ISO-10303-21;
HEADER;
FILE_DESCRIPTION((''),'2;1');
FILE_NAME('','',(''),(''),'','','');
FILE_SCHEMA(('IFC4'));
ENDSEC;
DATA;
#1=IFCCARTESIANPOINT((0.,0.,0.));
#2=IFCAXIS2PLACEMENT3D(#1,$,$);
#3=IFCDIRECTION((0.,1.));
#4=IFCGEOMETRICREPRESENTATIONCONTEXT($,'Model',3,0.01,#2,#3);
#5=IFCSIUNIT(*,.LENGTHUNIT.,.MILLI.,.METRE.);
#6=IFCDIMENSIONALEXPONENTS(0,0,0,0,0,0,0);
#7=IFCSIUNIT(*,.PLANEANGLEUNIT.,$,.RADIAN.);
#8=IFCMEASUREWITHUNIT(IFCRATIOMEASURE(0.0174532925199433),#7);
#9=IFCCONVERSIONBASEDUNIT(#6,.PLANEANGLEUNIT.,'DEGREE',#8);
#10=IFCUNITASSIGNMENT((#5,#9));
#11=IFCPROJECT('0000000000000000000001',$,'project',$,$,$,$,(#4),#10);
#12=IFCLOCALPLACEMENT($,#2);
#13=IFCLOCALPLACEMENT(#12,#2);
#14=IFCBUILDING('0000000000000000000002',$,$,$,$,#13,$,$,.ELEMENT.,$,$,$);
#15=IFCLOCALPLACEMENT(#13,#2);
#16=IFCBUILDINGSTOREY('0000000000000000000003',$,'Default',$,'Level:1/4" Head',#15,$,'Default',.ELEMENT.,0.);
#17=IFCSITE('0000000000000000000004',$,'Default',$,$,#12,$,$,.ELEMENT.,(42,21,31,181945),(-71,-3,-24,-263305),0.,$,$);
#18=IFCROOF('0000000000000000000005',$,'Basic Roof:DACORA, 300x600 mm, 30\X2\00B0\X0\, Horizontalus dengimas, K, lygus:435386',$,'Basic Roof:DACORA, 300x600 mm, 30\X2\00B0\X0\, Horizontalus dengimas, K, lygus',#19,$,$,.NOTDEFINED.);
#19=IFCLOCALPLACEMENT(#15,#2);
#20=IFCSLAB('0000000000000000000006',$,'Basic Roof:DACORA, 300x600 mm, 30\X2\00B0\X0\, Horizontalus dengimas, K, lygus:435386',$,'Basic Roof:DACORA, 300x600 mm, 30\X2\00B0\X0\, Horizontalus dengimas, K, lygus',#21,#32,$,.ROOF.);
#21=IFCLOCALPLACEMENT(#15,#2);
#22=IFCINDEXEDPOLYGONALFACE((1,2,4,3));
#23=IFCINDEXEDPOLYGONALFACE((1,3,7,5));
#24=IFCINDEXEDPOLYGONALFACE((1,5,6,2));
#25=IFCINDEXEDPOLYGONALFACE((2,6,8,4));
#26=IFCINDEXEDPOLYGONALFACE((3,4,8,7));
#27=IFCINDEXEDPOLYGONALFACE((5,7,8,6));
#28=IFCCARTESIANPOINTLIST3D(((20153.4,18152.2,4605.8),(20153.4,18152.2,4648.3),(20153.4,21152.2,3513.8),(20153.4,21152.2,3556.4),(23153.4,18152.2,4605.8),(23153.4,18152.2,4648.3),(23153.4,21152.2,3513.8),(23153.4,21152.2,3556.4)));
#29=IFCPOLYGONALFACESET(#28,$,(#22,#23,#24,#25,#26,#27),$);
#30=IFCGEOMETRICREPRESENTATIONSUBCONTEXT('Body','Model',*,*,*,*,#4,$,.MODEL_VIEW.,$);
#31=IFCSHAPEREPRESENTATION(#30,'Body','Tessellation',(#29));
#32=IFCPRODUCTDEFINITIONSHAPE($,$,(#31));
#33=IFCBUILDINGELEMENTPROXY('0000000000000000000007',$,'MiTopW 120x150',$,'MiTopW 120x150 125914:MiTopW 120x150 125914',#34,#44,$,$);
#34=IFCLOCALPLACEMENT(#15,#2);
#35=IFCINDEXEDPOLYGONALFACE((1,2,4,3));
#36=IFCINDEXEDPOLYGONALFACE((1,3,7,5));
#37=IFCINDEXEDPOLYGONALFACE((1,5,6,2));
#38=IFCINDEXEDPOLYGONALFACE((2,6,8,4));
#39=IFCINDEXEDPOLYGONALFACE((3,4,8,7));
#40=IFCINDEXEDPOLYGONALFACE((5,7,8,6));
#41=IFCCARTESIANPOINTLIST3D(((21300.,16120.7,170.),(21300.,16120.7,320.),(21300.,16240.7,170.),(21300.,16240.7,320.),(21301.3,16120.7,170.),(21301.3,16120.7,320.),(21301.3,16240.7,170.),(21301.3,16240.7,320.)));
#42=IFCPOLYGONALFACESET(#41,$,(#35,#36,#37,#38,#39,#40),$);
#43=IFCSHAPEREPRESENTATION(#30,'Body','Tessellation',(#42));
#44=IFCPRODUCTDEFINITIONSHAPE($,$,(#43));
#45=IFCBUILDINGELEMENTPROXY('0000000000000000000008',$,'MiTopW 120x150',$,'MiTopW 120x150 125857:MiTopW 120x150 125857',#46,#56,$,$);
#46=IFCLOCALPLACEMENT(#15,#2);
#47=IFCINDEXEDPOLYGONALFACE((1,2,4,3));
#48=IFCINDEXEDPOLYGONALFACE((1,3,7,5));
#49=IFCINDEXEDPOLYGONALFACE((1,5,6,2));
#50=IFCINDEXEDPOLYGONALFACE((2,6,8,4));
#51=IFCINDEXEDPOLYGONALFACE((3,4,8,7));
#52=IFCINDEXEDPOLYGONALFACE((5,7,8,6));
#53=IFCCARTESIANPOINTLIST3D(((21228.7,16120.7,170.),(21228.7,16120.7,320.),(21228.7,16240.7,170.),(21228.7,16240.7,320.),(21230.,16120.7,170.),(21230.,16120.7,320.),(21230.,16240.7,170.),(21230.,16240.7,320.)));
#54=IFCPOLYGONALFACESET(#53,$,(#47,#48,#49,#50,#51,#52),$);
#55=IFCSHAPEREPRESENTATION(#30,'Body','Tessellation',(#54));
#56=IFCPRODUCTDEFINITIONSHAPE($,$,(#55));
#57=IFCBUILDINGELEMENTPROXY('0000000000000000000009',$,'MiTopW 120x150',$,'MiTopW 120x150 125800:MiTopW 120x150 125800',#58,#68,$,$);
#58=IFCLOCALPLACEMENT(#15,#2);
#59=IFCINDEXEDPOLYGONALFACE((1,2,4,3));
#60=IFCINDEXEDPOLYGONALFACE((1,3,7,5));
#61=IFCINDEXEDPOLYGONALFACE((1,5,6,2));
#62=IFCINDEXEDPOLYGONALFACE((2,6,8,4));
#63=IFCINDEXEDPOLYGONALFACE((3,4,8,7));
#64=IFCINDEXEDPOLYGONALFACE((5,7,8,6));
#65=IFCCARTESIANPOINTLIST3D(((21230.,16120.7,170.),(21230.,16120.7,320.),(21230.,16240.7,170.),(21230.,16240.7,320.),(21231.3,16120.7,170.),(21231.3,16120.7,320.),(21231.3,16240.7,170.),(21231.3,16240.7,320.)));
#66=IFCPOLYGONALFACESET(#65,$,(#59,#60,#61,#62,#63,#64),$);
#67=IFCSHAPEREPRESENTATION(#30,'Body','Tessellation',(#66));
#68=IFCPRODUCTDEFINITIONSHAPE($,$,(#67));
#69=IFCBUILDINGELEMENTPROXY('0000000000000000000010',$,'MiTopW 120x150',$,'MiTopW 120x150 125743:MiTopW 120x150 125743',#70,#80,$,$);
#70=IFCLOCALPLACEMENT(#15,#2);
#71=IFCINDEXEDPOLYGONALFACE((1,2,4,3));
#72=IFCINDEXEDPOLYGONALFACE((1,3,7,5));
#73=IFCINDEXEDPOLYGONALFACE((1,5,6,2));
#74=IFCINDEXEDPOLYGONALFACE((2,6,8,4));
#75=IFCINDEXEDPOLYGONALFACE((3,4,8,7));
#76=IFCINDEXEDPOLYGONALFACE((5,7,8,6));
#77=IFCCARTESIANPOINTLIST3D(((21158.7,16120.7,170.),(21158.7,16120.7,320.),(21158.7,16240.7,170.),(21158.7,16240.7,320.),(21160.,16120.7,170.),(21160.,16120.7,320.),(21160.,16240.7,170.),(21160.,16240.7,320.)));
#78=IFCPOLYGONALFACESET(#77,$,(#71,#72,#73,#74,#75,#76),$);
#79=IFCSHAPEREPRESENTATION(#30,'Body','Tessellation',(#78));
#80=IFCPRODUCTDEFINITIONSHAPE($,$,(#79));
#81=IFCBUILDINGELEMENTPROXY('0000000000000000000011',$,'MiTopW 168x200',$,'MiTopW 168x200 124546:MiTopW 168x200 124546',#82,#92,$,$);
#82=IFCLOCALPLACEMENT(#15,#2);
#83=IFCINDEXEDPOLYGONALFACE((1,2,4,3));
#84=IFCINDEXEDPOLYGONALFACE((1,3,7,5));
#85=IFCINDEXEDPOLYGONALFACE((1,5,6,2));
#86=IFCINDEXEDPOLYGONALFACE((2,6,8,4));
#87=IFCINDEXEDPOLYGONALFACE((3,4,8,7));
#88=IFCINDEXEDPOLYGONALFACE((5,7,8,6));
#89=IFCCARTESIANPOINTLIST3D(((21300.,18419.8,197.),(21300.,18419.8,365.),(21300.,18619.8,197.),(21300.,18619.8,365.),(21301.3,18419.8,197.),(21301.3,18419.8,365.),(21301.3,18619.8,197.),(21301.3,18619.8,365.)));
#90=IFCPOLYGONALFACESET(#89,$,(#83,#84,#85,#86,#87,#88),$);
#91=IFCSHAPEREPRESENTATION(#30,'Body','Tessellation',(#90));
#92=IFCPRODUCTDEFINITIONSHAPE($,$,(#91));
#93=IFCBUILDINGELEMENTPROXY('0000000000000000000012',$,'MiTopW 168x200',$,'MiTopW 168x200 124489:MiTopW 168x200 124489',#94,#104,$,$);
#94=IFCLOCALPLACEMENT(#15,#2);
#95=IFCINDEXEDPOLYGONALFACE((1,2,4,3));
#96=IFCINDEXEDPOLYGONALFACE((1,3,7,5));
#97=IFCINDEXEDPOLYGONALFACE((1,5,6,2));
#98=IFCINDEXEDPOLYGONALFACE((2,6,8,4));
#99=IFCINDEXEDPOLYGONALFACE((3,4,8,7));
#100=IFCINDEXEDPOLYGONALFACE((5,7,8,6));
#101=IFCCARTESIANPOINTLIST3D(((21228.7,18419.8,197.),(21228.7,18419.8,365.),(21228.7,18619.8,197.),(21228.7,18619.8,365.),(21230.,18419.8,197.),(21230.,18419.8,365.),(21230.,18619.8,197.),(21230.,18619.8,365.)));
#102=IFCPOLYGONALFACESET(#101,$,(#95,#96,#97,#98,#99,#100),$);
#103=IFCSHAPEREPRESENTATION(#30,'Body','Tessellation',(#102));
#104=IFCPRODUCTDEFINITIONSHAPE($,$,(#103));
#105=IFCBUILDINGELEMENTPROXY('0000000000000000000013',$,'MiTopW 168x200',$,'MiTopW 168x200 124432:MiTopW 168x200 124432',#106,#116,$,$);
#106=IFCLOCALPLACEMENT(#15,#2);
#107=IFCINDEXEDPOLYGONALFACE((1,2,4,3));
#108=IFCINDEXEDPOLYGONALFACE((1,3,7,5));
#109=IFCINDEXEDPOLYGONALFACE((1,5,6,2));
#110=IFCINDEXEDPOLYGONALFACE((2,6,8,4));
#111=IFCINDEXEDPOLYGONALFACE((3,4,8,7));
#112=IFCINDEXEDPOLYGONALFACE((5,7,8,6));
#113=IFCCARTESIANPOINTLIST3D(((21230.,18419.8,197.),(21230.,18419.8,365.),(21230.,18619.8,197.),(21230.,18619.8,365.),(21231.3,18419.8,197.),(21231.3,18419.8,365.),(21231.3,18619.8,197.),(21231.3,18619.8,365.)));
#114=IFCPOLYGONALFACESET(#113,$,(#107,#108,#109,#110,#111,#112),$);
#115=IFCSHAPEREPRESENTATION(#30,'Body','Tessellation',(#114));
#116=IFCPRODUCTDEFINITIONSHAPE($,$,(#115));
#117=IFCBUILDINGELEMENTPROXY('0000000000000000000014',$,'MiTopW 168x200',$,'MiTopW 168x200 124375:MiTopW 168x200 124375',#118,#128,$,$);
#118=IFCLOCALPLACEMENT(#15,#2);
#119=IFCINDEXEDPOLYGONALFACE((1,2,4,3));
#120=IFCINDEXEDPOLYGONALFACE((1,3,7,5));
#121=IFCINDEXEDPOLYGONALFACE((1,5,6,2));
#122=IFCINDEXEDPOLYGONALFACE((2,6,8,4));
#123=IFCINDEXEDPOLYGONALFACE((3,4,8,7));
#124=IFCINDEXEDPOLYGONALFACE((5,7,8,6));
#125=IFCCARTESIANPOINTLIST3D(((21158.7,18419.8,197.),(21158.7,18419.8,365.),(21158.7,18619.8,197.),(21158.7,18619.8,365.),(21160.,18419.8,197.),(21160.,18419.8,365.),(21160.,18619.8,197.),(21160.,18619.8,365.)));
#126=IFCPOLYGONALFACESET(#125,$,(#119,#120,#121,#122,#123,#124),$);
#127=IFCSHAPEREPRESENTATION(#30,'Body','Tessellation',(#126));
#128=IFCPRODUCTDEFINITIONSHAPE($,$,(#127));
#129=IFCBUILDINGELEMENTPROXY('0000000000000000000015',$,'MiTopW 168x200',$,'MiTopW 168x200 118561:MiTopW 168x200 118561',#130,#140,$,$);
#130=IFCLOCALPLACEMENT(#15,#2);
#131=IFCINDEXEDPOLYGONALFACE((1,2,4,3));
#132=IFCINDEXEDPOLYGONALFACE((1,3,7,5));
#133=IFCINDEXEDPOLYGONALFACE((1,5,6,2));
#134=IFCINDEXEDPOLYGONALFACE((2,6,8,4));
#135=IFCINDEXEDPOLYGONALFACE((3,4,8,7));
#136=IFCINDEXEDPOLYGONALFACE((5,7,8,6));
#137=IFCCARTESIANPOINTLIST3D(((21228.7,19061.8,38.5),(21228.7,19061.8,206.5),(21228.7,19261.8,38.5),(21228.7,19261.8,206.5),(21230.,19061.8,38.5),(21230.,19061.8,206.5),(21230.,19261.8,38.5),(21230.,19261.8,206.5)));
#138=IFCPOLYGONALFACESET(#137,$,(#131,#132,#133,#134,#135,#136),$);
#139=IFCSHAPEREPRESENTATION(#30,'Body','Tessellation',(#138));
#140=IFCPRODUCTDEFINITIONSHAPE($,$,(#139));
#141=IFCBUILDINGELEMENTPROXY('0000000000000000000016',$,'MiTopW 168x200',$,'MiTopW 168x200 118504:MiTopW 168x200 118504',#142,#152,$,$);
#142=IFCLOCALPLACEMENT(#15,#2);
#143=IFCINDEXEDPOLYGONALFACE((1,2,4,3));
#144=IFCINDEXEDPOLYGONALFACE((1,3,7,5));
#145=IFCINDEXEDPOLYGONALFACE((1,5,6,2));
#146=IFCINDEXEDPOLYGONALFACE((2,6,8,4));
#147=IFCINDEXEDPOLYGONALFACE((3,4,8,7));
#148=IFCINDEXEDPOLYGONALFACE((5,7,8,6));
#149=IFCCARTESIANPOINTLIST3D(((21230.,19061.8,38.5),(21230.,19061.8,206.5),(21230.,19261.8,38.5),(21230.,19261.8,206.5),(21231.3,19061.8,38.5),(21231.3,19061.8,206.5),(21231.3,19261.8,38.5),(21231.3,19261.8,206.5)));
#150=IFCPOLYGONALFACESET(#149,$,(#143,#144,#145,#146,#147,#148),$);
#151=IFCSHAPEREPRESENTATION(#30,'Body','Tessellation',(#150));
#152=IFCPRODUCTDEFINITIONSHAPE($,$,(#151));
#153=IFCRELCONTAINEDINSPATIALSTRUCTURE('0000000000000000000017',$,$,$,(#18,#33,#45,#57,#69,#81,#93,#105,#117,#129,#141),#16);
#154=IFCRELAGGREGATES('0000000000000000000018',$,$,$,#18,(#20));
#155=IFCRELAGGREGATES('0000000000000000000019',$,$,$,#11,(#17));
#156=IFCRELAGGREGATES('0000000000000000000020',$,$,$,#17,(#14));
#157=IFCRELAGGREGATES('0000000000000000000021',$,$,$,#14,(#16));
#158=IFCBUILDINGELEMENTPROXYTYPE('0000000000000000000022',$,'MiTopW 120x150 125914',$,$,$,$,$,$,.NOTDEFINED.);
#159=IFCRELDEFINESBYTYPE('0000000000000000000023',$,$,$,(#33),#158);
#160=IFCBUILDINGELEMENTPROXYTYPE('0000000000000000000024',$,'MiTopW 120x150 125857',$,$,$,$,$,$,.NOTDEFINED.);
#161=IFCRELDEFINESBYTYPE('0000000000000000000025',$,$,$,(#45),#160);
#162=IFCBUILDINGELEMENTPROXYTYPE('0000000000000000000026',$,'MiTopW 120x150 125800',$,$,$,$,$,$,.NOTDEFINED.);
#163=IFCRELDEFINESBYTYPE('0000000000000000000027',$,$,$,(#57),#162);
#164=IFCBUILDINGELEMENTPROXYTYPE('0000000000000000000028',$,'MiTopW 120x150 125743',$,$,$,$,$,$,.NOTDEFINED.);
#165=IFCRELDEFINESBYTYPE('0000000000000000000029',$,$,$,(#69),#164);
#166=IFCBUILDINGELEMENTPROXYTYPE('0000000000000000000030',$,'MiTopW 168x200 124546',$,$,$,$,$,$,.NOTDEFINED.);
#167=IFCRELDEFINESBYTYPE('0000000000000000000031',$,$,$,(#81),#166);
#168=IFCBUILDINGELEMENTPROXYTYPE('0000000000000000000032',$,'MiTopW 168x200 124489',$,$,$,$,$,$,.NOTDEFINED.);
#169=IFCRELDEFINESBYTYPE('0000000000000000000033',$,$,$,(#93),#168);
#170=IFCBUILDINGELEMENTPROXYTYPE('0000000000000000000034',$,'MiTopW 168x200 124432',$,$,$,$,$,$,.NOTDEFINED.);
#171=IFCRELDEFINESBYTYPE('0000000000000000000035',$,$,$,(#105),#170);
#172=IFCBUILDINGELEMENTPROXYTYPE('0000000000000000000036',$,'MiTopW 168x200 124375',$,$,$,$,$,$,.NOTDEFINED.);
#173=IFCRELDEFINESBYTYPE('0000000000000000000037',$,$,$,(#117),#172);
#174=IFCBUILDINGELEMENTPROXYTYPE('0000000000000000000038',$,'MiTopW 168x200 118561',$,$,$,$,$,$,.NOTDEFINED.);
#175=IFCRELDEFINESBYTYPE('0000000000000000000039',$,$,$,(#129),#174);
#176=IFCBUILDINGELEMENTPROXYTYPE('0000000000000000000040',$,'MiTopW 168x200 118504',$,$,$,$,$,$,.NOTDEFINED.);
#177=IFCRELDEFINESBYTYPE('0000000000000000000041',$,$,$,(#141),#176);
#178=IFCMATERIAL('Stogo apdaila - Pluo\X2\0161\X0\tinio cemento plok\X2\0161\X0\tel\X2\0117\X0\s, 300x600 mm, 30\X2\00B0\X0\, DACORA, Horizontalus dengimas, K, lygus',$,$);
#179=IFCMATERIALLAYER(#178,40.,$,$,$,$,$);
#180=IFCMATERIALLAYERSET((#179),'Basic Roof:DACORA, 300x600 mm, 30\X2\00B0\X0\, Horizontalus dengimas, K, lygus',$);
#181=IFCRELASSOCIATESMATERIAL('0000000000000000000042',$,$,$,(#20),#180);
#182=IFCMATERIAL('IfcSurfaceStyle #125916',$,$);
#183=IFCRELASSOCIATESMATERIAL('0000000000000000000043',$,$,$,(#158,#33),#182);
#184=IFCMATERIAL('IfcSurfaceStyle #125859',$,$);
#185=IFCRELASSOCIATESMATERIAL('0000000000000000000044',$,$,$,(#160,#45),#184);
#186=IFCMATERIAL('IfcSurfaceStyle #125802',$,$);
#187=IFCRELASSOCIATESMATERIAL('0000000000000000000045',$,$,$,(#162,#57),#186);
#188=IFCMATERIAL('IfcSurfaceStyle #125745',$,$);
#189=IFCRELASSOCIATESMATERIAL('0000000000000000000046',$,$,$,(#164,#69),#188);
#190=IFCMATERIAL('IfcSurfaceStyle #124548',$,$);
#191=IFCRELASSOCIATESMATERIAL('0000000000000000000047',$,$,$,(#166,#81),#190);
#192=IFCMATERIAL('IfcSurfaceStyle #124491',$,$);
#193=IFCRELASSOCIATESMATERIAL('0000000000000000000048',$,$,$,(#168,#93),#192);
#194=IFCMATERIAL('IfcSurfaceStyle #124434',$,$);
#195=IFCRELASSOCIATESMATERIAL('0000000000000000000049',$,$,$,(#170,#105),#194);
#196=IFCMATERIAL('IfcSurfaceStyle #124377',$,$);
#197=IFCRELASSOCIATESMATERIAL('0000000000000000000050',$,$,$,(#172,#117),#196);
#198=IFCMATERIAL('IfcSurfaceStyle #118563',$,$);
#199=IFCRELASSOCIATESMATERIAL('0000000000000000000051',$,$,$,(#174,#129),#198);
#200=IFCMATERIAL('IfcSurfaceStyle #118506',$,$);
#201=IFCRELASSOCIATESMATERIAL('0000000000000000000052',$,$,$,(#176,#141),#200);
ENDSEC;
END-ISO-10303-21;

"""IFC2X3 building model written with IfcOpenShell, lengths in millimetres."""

from ifc_helpers import new_model, entity, si_unit, converted_unit, direction, frame, frame_2d, origin, origin_2d_with_axis, place, context, subcontext, project, spatial, rectangle, extrude, source, transform, mapped, material, layer, layer_set, type_object, type_shapes, element, aggregate, save


model = new_model("IFC2X3")

# Units and contexts
model_context = context("Model", 3, precision=0.01, world=origin(), true_north=direction((0.0, 1.0)))
body_context = subcontext(model_context, "Body", "Model", "MODEL_VIEW")
ifc_project = project(units=[si_unit("LENGTHUNIT", "METRE", prefix="MILLI"), converted_unit("PLANEANGLEUNIT", "DEGREE", entity("IfcRatioMeasure", 0.0174532925199433), si_unit("PLANEANGLEUNIT", "RADIAN"), dimensions=[0, 0, 0, 0, 0, 0, 0])], contexts=[model_context])

# Site, building, storey
site_placement = place(None, origin())
site = spatial("IfcSite", under=ifc_project, at=site_placement, Name="Default", CompositionType="ELEMENT", RefLatitude=(42, 21, 31, 181945), RefLongitude=(-71, -3, -24, -263305), RefElevation=0.0)
building_placement = place(site_placement, origin())
building = spatial("IfcBuilding", under=site, at=building_placement, CompositionType="ELEMENT")
storey_placement = place(building_placement, origin())
storey = spatial("IfcBuildingStorey", under=building, at=storey_placement, Name="Default", ObjectType="Level:1/4\" Head", LongName="Default", CompositionType="ELEMENT", Elevation=0.0)

# Roof, slab
roof_placement = place(storey_placement, frame((20153.4, 18152.2, 3513.8)))
roof = element("IfcRoof", 1, at=roof_placement, inside=storey, Name="Basic Roof:DACORA, 300x600 mm, 30°, Horizontalus dengimas, K, lygus:435386", ObjectType="Basic Roof:DACORA, 300x600 mm, 30°, Horizontalus dengimas, K, lygus", ShapeType="NOTDEFINED")
ifc_material_1 = material(Name="Stogo apdaila - Pluoštinio cemento plokštelės, 300x600 mm, 30°, DACORA, Horizontalus dengimas, K, lygus")
ifc_layer = layer(ifc_material_1, 40.0)
ifc_layer_set = layer_set([ifc_layer], Name="Basic Roof:DACORA, 300x600 mm, 30°, Horizontalus dengimas, K, lygus")
slab_placement = place(roof_placement, origin())
slab = element("IfcSlab", 2, at=slab_placement, material=ifc_layer_set, Name="Basic Roof:DACORA, 300x600 mm, 30°, Horizontalus dengimas, K, lygus:435386", ObjectType="Basic Roof:DACORA, 300x600 mm, 30°, Horizontalus dengimas, K, lygus", PredefinedType="ROOF", context=body_context, shape_type="SweptSolid", body=[
    extrude(rectangle(XDim=3192.5, YDim=3000.0, at=frame_2d((0.0, 0.0), x_axis=(0.0, 1.0))), frame((1500.0, 1500.0, 546.0), z_axis=(0.0, 0.34202, 0.939693), x_axis=(1.0, 0.0, 0.0)), (0.0, -0.34202, 0.939693), 42.6),
])
aggregate(roof, [slab])

# Building element proxies
ifc_material_2 = material(Name="IfcSurfaceStyle #125916")
building_element_proxy_type_1 = type_object("IfcBuildingElementProxyType", Name="MiTopW 120x150 125914", PredefinedType="NOTDEFINED", material=ifc_material_2)
shared_shape_1 = source(origin(), body_context, "Body", "SweptSolid", [
    extrude(rectangle(XDim=150.0, YDim=120.0, at=origin_2d_with_axis()), frame((75.0, 60.0, 0.0), z_axis=(0.0, 0.0, 1.0), x_axis=(-1.0, 0.0, 0.0)), (0.0, 0.0, 1.0), 1.3),
])
type_shapes(building_element_proxy_type_1, [shared_shape_1])
proxy_1_placement = place(building_placement, frame((21301.3, 16120.7, 170.0), z_axis=(-1.0, 0.0, 0.0), x_axis=(0.0, 0.0, 1.0)))
element("IfcBuildingElementProxy", 3, at=proxy_1_placement, inside=storey, type_object=building_element_proxy_type_1, material=ifc_material_2, Name="MiTopW 120x150", ObjectType="MiTopW 120x150 125914:MiTopW 120x150 125914", context=body_context, shape_type="MappedRepresentation", body=[
    mapped(shared_shape_1, transform((0.0, 0.0, 0.0), scale=1.0)),
])
ifc_material_3 = material(Name="IfcSurfaceStyle #125859")
building_element_proxy_type_2 = type_object("IfcBuildingElementProxyType", Name="MiTopW 120x150 125857", PredefinedType="NOTDEFINED", material=ifc_material_3)
shared_shape_2 = source(origin(), body_context, "Body", "SweptSolid", [
    extrude(rectangle(XDim=150.0, YDim=120.0, at=origin_2d_with_axis()), frame((75.0, 60.0, 0.0), z_axis=(0.0, 0.0, 1.0), x_axis=(-1.0, 0.0, 0.0)), (0.0, 0.0, 1.0), 1.3),
])
type_shapes(building_element_proxy_type_2, [shared_shape_2])
proxy_2_placement = place(building_placement, frame((21230.0, 16120.7, 170.0), z_axis=(-1.0, 0.0, 0.0), x_axis=(0.0, 0.0, 1.0)))
element("IfcBuildingElementProxy", 4, at=proxy_2_placement, inside=storey, type_object=building_element_proxy_type_2, material=ifc_material_3, Name="MiTopW 120x150", ObjectType="MiTopW 120x150 125857:MiTopW 120x150 125857", context=body_context, shape_type="MappedRepresentation", body=[
    mapped(shared_shape_2, transform((0.0, 0.0, 0.0), scale=1.0)),
])
ifc_material_4 = material(Name="IfcSurfaceStyle #125802")
building_element_proxy_type_3 = type_object("IfcBuildingElementProxyType", Name="MiTopW 120x150 125800", PredefinedType="NOTDEFINED", material=ifc_material_4)
shared_shape_3 = source(origin(), body_context, "Body", "SweptSolid", [
    extrude(rectangle(XDim=150.0, YDim=120.0, at=origin_2d_with_axis()), frame((75.0, 60.0, 0.0), z_axis=(0.0, 0.0, 1.0), x_axis=(-1.0, 0.0, 0.0)), (0.0, 0.0, 1.0), 1.3),
])
type_shapes(building_element_proxy_type_3, [shared_shape_3])
proxy_3_placement = place(building_placement, frame((21231.3, 16120.7, 170.0), z_axis=(-1.0, 0.0, 0.0), x_axis=(0.0, 0.0, 1.0)))
element("IfcBuildingElementProxy", 5, at=proxy_3_placement, inside=storey, type_object=building_element_proxy_type_3, material=ifc_material_4, Name="MiTopW 120x150", ObjectType="MiTopW 120x150 125800:MiTopW 120x150 125800", context=body_context, shape_type="MappedRepresentation", body=[
    mapped(shared_shape_3, transform((0.0, 0.0, 0.0), scale=1.0)),
])
ifc_material_5 = material(Name="IfcSurfaceStyle #125745")
building_element_proxy_type_4 = type_object("IfcBuildingElementProxyType", Name="MiTopW 120x150 125743", PredefinedType="NOTDEFINED", material=ifc_material_5)
shared_shape_4 = source(origin(), body_context, "Body", "SweptSolid", [
    extrude(rectangle(XDim=150.0, YDim=120.0, at=origin_2d_with_axis()), frame((75.0, 60.0, 0.0), z_axis=(0.0, 0.0, 1.0), x_axis=(-1.0, 0.0, 0.0)), (0.0, 0.0, 1.0), 1.3),
])
type_shapes(building_element_proxy_type_4, [shared_shape_4])
proxy_4_placement = place(building_placement, frame((21160.0, 16120.7, 170.0), z_axis=(-1.0, 0.0, 0.0), x_axis=(0.0, 0.0, 1.0)))
element("IfcBuildingElementProxy", 6, at=proxy_4_placement, inside=storey, type_object=building_element_proxy_type_4, material=ifc_material_5, Name="MiTopW 120x150", ObjectType="MiTopW 120x150 125743:MiTopW 120x150 125743", context=body_context, shape_type="MappedRepresentation", body=[
    mapped(shared_shape_4, transform((0.0, 0.0, 0.0), scale=1.0)),
])
ifc_material_6 = material(Name="IfcSurfaceStyle #124548")
building_element_proxy_type_5 = type_object("IfcBuildingElementProxyType", Name="MiTopW 168x200 124546", PredefinedType="NOTDEFINED", material=ifc_material_6)
shared_shape_5 = source(origin(), body_context, "Body", "SweptSolid", [
    extrude(rectangle(XDim=200.0, YDim=168.0, at=origin_2d_with_axis()), frame((100.0, 84.0, 0.0), z_axis=(0.0, 0.0, 1.0), x_axis=(-1.0, 0.0, 0.0)), (0.0, 0.0, 1.0), 1.3),
])
type_shapes(building_element_proxy_type_5, [shared_shape_5])
proxy_5_placement = place(building_placement, frame((21301.3, 18619.8, 197.0), z_axis=(-1.0, 0.0, 0.0), x_axis=(0.0, -1.0, 0.0)))
element("IfcBuildingElementProxy", 7, at=proxy_5_placement, inside=storey, type_object=building_element_proxy_type_5, material=ifc_material_6, Name="MiTopW 168x200", ObjectType="MiTopW 168x200 124546:MiTopW 168x200 124546", context=body_context, shape_type="MappedRepresentation", body=[
    mapped(shared_shape_5, transform((0.0, 0.0, 0.0), scale=1.0)),
])
ifc_material_7 = material(Name="IfcSurfaceStyle #124491")
building_element_proxy_type_6 = type_object("IfcBuildingElementProxyType", Name="MiTopW 168x200 124489", PredefinedType="NOTDEFINED", material=ifc_material_7)
shared_shape_6 = source(origin(), body_context, "Body", "SweptSolid", [
    extrude(rectangle(XDim=200.0, YDim=168.0, at=origin_2d_with_axis()), frame((100.0, 84.0, 0.0), z_axis=(0.0, 0.0, 1.0), x_axis=(-1.0, 0.0, 0.0)), (0.0, 0.0, 1.0), 1.3),
])
type_shapes(building_element_proxy_type_6, [shared_shape_6])
proxy_6_placement = place(building_placement, frame((21230.0, 18619.8, 197.0), z_axis=(-1.0, 0.0, 0.0), x_axis=(0.0, -1.0, 0.0)))
element("IfcBuildingElementProxy", 8, at=proxy_6_placement, inside=storey, type_object=building_element_proxy_type_6, material=ifc_material_7, Name="MiTopW 168x200", ObjectType="MiTopW 168x200 124489:MiTopW 168x200 124489", context=body_context, shape_type="MappedRepresentation", body=[
    mapped(shared_shape_6, transform((0.0, 0.0, 0.0), scale=1.0)),
])
ifc_material_8 = material(Name="IfcSurfaceStyle #124434")
building_element_proxy_type_7 = type_object("IfcBuildingElementProxyType", Name="MiTopW 168x200 124432", PredefinedType="NOTDEFINED", material=ifc_material_8)
shared_shape_7 = source(origin(), body_context, "Body", "SweptSolid", [
    extrude(rectangle(XDim=200.0, YDim=168.0, at=origin_2d_with_axis()), frame((100.0, 84.0, 0.0), z_axis=(0.0, 0.0, 1.0), x_axis=(-1.0, 0.0, 0.0)), (0.0, 0.0, 1.0), 1.3),
])
type_shapes(building_element_proxy_type_7, [shared_shape_7])
proxy_7_placement = place(building_placement, frame((21231.3, 18619.8, 197.0), z_axis=(-1.0, 0.0, 0.0), x_axis=(0.0, -1.0, 0.0)))
element("IfcBuildingElementProxy", 9, at=proxy_7_placement, inside=storey, type_object=building_element_proxy_type_7, material=ifc_material_8, Name="MiTopW 168x200", ObjectType="MiTopW 168x200 124432:MiTopW 168x200 124432", context=body_context, shape_type="MappedRepresentation", body=[
    mapped(shared_shape_7, transform((0.0, 0.0, 0.0), scale=1.0)),
])
ifc_material_9 = material(Name="IfcSurfaceStyle #124377")
building_element_proxy_type_8 = type_object("IfcBuildingElementProxyType", Name="MiTopW 168x200 124375", PredefinedType="NOTDEFINED", material=ifc_material_9)
shared_shape_8 = source(origin(), body_context, "Body", "SweptSolid", [
    extrude(rectangle(XDim=200.0, YDim=168.0, at=origin_2d_with_axis()), frame((100.0, 84.0, 0.0), z_axis=(0.0, 0.0, 1.0), x_axis=(-1.0, 0.0, 0.0)), (0.0, 0.0, 1.0), 1.3),
])
type_shapes(building_element_proxy_type_8, [shared_shape_8])
proxy_8_placement = place(building_placement, frame((21160.0, 18619.8, 197.0), z_axis=(-1.0, 0.0, 0.0), x_axis=(0.0, -1.0, 0.0)))
element("IfcBuildingElementProxy", 10, at=proxy_8_placement, inside=storey, type_object=building_element_proxy_type_8, material=ifc_material_9, Name="MiTopW 168x200", ObjectType="MiTopW 168x200 124375:MiTopW 168x200 124375", context=body_context, shape_type="MappedRepresentation", body=[
    mapped(shared_shape_8, transform((0.0, 0.0, 0.0), scale=1.0)),
])
ifc_material_10 = material(Name="IfcSurfaceStyle #118563")
building_element_proxy_type_9 = type_object("IfcBuildingElementProxyType", Name="MiTopW 168x200 118561", PredefinedType="NOTDEFINED", material=ifc_material_10)
shared_shape_9 = source(origin(), body_context, "Body", "SweptSolid", [
    extrude(rectangle(XDim=200.0, YDim=168.0, at=origin_2d_with_axis()), frame((100.0, 84.0, 0.0), z_axis=(0.0, 0.0, 1.0), x_axis=(-1.0, 0.0, 0.0)), (0.0, 0.0, 1.0), 1.3),
])
type_shapes(building_element_proxy_type_9, [shared_shape_9])
proxy_9_placement = place(building_placement, frame((21230.0, 19061.8, 206.5), z_axis=(-1.0, 0.0, 0.0), x_axis=(0.0, 1.0, 0.0)))
element("IfcBuildingElementProxy", 11, at=proxy_9_placement, inside=storey, type_object=building_element_proxy_type_9, material=ifc_material_10, Name="MiTopW 168x200", ObjectType="MiTopW 168x200 118561:MiTopW 168x200 118561", context=body_context, shape_type="MappedRepresentation", body=[
    mapped(shared_shape_9, transform((0.0, 0.0, 0.0), scale=1.0)),
])
ifc_material_11 = material(Name="IfcSurfaceStyle #118506")
building_element_proxy_type_10 = type_object("IfcBuildingElementProxyType", Name="MiTopW 168x200 118504", PredefinedType="NOTDEFINED", material=ifc_material_11)
shared_shape_10 = source(origin(), body_context, "Body", "SweptSolid", [
    extrude(rectangle(XDim=200.0, YDim=168.0, at=origin_2d_with_axis()), frame((100.0, 84.0, 0.0), z_axis=(0.0, 0.0, 1.0), x_axis=(-1.0, 0.0, 0.0)), (0.0, 0.0, 1.0), 1.3),
])
type_shapes(building_element_proxy_type_10, [shared_shape_10])
proxy_10_placement = place(building_placement, frame((21231.3, 19061.8, 206.5), z_axis=(-1.0, 0.0, 0.0), x_axis=(0.0, 1.0, 0.0)))
element("IfcBuildingElementProxy", 12, at=proxy_10_placement, inside=storey, type_object=building_element_proxy_type_10, material=ifc_material_11, Name="MiTopW 168x200", ObjectType="MiTopW 168x200 118504:MiTopW 168x200 118504", context=body_context, shape_type="MappedRepresentation", body=[
    mapped(shared_shape_10, transform((0.0, 0.0, 0.0), scale=1.0)),
])

save(model, "model.ifc")
